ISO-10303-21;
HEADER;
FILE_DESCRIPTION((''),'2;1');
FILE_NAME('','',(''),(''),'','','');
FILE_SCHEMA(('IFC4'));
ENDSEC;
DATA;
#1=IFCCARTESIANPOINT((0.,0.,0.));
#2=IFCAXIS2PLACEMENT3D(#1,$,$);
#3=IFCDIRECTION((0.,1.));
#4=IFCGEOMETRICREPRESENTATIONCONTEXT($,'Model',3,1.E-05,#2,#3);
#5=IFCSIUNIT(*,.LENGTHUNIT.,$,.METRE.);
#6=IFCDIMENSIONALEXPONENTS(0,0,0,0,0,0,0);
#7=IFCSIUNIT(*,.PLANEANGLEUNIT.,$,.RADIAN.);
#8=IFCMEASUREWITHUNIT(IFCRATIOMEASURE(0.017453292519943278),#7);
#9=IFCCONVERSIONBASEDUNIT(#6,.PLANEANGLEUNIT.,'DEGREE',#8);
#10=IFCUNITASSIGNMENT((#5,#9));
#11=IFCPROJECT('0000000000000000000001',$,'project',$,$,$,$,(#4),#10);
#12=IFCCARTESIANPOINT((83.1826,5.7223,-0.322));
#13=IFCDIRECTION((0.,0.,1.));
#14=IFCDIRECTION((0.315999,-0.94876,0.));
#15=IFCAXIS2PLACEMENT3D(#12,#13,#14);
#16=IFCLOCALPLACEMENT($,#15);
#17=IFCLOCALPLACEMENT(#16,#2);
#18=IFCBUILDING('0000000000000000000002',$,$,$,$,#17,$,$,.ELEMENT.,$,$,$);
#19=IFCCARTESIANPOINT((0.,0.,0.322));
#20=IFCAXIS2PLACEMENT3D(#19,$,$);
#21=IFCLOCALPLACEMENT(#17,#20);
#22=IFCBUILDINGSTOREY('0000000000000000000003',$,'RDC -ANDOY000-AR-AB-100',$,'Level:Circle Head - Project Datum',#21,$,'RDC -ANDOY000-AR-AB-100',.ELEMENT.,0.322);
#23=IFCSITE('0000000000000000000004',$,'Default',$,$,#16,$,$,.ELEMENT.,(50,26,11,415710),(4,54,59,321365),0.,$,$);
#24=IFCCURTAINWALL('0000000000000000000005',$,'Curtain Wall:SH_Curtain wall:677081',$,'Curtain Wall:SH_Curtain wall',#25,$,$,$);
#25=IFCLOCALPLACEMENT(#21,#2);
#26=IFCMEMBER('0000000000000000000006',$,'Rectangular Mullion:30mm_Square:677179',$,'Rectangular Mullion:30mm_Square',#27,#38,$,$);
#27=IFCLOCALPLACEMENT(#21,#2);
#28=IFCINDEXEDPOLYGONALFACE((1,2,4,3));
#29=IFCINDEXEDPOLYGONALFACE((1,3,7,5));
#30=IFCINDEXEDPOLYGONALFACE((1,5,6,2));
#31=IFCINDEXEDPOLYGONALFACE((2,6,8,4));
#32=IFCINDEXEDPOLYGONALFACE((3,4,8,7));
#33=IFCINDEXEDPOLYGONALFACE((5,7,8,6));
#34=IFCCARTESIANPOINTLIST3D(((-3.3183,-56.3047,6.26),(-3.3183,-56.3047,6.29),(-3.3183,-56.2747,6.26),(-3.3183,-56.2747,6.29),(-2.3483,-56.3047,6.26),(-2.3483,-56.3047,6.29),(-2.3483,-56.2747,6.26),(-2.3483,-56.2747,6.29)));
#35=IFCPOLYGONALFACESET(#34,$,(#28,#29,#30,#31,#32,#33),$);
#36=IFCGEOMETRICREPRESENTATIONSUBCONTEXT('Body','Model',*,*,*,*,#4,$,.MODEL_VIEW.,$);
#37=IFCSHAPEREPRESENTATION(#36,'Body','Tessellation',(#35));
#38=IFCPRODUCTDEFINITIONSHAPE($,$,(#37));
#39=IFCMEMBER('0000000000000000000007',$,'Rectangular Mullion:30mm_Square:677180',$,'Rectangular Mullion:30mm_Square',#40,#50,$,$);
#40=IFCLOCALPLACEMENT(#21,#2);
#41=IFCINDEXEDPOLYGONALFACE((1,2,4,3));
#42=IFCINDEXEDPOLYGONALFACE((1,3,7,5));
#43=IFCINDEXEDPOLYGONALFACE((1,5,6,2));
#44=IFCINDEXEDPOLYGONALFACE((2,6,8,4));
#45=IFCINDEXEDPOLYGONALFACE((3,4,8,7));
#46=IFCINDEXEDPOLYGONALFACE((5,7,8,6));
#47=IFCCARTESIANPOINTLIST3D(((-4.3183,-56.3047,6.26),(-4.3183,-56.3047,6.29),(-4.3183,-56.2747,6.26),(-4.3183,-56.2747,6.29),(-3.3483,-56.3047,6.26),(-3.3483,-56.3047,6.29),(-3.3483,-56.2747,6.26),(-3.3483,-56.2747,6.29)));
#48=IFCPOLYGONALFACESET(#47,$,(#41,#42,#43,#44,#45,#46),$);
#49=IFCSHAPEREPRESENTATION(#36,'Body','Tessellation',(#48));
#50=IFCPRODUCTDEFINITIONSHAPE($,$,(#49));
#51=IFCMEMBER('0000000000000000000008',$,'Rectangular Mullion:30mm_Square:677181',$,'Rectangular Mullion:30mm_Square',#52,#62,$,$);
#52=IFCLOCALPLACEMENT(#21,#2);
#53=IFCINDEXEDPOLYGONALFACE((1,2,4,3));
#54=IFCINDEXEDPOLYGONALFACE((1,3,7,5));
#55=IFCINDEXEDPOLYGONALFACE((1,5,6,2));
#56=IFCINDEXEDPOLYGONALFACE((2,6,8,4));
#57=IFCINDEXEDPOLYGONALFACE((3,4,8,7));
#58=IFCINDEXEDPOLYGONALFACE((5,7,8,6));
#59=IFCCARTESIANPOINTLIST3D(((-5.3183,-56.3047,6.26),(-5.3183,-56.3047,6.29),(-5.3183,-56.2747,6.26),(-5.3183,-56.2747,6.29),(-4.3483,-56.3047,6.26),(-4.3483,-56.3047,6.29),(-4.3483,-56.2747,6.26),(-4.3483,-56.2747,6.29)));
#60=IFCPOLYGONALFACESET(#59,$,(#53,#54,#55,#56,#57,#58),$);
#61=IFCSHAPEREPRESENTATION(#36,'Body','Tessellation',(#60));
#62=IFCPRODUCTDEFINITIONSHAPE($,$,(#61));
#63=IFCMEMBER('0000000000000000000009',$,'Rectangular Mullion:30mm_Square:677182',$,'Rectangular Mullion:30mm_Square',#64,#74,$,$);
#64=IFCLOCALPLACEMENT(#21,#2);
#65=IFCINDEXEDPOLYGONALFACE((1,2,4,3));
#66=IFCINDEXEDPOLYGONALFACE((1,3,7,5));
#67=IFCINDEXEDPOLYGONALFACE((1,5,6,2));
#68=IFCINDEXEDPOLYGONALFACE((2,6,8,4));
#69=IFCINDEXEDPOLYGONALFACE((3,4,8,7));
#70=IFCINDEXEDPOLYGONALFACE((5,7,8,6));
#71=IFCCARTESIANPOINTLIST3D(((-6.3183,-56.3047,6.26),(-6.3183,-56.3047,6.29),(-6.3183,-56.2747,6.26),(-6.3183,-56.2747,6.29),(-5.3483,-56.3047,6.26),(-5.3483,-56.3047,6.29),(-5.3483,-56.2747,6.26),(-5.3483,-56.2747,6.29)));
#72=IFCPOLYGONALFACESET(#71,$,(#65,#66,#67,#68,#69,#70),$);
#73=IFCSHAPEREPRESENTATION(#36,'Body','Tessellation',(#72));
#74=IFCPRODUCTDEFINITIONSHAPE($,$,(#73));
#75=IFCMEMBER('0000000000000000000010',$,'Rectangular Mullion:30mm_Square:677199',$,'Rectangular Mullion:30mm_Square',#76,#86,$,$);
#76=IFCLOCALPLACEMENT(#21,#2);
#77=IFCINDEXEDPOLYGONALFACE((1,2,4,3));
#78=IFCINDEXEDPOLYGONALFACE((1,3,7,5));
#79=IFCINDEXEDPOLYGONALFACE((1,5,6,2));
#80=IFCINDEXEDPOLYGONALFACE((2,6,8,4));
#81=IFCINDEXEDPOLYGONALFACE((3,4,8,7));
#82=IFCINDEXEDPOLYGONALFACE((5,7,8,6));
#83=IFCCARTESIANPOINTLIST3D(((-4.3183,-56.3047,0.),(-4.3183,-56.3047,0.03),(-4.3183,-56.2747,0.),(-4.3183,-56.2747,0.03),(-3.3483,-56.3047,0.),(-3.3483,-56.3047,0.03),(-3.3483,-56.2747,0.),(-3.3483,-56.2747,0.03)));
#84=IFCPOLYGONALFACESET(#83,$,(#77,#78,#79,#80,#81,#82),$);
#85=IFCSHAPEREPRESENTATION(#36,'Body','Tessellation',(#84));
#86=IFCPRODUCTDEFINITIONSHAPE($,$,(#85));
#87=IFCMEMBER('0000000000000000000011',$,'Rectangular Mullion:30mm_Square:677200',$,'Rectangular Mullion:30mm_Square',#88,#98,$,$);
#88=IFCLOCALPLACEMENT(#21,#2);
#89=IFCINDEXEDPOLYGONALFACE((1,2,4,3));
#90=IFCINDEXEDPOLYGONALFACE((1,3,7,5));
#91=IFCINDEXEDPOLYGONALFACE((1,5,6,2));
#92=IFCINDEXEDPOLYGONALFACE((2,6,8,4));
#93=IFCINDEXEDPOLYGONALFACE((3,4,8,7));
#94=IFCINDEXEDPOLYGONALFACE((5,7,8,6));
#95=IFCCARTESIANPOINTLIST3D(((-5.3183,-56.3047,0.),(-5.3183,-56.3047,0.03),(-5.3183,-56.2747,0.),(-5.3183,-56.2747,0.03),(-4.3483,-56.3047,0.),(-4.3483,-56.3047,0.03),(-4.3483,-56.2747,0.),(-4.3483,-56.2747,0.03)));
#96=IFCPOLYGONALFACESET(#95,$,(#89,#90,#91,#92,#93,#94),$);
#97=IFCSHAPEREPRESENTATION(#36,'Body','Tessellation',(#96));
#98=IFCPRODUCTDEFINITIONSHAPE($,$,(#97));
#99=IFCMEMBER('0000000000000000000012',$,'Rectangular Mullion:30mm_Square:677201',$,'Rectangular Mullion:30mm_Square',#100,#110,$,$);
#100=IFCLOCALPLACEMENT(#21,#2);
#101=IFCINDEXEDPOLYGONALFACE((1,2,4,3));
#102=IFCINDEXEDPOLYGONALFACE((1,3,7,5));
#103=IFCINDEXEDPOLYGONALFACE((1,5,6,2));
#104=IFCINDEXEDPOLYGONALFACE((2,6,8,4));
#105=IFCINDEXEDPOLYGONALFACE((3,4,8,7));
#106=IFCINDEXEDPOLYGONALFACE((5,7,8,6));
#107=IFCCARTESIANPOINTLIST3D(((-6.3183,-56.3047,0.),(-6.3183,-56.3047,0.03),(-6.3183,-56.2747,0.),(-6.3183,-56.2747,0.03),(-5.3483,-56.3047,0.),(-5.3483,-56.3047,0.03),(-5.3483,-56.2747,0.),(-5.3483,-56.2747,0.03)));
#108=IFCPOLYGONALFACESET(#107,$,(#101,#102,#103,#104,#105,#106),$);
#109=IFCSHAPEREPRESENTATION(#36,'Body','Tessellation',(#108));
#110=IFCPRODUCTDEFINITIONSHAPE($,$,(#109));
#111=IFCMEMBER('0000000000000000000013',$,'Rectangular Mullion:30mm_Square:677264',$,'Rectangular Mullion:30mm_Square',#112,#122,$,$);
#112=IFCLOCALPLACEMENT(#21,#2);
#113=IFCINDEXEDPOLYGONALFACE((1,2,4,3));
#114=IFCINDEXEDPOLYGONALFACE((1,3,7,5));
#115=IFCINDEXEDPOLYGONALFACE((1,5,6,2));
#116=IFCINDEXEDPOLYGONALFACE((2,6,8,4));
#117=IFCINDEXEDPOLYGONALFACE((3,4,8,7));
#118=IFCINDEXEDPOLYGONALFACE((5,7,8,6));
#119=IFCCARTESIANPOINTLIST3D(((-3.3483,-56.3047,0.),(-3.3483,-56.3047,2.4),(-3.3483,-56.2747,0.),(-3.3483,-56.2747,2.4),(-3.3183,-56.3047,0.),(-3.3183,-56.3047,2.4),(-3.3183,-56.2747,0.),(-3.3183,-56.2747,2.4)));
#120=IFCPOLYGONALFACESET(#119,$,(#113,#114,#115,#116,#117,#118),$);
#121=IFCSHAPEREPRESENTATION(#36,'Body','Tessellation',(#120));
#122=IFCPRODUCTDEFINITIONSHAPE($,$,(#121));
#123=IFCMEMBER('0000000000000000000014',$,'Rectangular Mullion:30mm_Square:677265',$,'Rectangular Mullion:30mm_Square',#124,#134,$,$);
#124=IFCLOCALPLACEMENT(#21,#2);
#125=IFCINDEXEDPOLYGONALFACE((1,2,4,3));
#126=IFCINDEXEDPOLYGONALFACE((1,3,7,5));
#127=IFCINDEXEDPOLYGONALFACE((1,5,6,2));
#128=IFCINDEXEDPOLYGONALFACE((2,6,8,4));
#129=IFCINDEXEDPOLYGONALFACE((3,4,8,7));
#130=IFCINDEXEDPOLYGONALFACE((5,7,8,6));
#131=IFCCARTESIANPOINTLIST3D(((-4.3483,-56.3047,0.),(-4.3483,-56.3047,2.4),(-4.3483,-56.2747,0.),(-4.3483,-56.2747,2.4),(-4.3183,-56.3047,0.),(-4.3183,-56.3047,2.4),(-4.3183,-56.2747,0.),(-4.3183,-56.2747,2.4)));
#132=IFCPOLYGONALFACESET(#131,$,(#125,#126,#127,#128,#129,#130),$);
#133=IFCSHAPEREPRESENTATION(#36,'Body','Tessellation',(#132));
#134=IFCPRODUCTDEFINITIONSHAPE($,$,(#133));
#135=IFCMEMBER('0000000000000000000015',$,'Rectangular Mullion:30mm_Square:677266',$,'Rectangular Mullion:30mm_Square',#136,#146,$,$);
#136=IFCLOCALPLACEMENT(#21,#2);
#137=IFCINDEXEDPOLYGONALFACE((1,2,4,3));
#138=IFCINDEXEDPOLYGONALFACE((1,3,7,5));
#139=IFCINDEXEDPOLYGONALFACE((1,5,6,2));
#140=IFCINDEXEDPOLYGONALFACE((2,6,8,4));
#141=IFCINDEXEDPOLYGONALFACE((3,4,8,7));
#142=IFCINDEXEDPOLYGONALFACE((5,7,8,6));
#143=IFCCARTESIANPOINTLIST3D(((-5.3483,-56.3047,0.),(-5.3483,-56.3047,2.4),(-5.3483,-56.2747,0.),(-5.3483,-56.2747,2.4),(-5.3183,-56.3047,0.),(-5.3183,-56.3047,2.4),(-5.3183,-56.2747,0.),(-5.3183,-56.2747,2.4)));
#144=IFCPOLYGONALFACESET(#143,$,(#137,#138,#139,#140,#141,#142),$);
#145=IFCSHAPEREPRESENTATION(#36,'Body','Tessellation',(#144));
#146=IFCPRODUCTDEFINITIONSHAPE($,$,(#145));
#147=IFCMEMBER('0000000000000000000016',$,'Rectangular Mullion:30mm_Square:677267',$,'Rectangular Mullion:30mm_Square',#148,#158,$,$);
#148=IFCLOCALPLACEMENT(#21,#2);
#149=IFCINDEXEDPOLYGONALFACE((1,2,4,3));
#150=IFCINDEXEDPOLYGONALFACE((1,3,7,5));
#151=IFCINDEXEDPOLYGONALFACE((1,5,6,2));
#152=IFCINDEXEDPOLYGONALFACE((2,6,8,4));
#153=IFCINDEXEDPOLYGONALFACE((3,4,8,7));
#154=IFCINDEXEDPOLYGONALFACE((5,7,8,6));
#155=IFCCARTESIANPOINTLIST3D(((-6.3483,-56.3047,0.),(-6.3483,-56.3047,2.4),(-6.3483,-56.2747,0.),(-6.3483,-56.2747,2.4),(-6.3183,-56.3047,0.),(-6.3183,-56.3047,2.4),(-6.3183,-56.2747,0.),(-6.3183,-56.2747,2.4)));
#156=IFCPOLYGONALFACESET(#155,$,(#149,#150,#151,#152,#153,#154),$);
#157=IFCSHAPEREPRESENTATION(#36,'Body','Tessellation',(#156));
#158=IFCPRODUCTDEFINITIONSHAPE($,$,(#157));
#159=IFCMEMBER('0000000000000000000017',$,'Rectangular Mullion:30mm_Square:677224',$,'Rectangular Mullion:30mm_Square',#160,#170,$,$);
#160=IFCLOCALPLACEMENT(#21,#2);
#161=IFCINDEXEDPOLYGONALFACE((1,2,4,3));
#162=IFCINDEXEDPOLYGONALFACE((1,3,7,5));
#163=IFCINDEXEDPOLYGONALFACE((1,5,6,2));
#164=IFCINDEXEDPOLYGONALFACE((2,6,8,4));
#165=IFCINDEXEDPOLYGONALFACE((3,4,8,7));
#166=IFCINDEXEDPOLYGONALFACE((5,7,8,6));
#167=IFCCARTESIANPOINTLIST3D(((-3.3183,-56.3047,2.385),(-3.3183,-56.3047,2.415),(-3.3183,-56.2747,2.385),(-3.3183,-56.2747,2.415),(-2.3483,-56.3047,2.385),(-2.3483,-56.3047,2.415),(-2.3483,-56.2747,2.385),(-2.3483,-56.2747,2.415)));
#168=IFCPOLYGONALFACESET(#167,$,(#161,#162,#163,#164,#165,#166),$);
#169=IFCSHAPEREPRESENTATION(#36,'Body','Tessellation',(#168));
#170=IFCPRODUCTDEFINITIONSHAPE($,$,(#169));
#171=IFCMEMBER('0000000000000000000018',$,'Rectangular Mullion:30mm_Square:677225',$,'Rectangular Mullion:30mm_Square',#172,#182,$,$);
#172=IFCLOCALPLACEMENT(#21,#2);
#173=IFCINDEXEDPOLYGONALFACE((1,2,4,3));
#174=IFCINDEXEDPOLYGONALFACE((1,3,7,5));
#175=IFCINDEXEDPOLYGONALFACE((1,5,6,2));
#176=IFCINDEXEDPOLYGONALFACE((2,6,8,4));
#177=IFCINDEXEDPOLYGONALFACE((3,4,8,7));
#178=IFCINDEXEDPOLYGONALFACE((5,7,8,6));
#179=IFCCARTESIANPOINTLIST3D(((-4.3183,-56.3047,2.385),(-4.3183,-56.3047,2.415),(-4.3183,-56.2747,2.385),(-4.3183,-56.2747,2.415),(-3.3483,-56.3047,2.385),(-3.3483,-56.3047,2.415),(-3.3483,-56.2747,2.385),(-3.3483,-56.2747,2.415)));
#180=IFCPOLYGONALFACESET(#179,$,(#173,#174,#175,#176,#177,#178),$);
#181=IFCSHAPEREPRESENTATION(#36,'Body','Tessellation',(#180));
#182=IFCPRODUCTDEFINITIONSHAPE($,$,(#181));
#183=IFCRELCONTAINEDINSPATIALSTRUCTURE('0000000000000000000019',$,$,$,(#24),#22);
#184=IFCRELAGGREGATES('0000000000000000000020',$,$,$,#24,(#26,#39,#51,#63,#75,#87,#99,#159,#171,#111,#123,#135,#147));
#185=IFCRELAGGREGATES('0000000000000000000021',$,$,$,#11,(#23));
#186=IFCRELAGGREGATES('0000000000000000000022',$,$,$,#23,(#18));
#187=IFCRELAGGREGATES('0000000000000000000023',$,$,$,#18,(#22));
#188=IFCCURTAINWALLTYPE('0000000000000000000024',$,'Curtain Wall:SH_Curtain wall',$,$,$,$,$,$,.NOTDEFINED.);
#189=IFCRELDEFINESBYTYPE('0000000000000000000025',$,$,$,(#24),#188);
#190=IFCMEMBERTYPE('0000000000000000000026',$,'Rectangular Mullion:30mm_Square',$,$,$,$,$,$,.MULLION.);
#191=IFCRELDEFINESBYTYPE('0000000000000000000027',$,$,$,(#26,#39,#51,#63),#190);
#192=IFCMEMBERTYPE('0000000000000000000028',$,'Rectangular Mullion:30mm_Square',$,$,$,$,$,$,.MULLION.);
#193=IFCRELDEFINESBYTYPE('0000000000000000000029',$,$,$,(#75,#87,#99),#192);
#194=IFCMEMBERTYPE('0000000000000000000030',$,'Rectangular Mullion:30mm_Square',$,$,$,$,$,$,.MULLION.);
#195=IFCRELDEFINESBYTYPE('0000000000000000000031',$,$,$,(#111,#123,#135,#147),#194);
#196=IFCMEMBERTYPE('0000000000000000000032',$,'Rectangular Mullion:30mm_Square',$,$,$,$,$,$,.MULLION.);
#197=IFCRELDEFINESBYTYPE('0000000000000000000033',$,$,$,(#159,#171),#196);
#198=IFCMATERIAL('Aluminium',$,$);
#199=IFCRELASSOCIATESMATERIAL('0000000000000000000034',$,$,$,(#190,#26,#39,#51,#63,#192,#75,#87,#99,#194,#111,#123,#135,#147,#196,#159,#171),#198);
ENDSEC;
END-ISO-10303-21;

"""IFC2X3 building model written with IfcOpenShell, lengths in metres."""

from ifc_helpers import new_model, entity, si_unit, converted_unit, direction, frame, origin, origin_2d_with_axis, place, context, subcontext, project, spatial, rectangle, extrude, source, transform, mapped, material, type_object, type_shapes, element, aggregate, save


model = new_model("IFC2X3")

# Units and contexts
model_context = context("Model", 3, precision=1e-05, world=origin(), true_north=direction((0.0, 1.0)))
body_context = subcontext(model_context, "Body", "Model", "MODEL_VIEW")
ifc_project = project(units=[si_unit("LENGTHUNIT", "METRE"), converted_unit("PLANEANGLEUNIT", "DEGREE", entity("IfcRatioMeasure", 0.017453292519943278), si_unit("PLANEANGLEUNIT", "RADIAN"), dimensions=[0, 0, 0, 0, 0, 0, 0])], contexts=[model_context])

# Site, building, storey
site_placement = place(None, frame((83.1826, 5.7223, -0.322), z_axis=(0.0, 0.0, 1.0), x_axis=(0.315999, -0.94876, 0.0)))
site = spatial("IfcSite", under=ifc_project, at=site_placement, Name="Default", CompositionType="ELEMENT", RefLatitude=(50, 26, 11, 415710), RefLongitude=(4, 54, 59, 321365), RefElevation=0.0)
building_placement = place(site_placement, origin())
building = spatial("IfcBuilding", under=site, at=building_placement, CompositionType="ELEMENT")
storey_placement = place(building_placement, frame((0.0, 0.0, 0.322)))
storey = spatial("IfcBuildingStorey", under=building, at=storey_placement, Name="RDC -ANDOY000-AR-AB-100", ObjectType="Level:Circle Head - Project Datum", LongName="RDC -ANDOY000-AR-AB-100", CompositionType="ELEMENT", Elevation=0.322)

# Curtain wall, members
curtain_wall_type = type_object("IfcCurtainWallType", Name="Curtain Wall:SH_Curtain wall", PredefinedType="NOTDEFINED")
curtain_wall_placement = place(storey_placement, frame((0.0, 0.0, -0.322)))
curtain_wall = element("IfcCurtainWall", 1, at=curtain_wall_placement, inside=storey, type_object=curtain_wall_type, Name="Curtain Wall:SH_Curtain wall:677081", ObjectType="Curtain Wall:SH_Curtain wall")
ifc_material_1 = material(Name="Aluminium")
member_type_1 = type_object("IfcMemberType", Name="Rectangular Mullion:30mm_Square", PredefinedType="MULLION", material=ifc_material_1)
shared_shape_1 = source(origin(), body_context, "Body", "SweptSolid", [
    extrude(rectangle(XDim=0.03, YDim=0.03, at=origin_2d_with_axis()), frame((-0.015, 0.0, -0.97), z_axis=(0.0, 0.0, 1.0), x_axis=(0.0, -1.0, 0.0)), (0.0, 0.0, 1.0), 0.97),
])
type_shapes(member_type_1, [shared_shape_1])
member_1_placement = place(curtain_wall_placement, frame((-3.3183, -56.2897, 6.612), z_axis=(-1.0, 0.0, 0.0), x_axis=(0.0, 0.0, 1.0)))
member_1 = element("IfcMember", 2, at=member_1_placement, type_object=member_type_1, material=ifc_material_1, Name="Rectangular Mullion:30mm_Square:677179", ObjectType="Rectangular Mullion:30mm_Square", context=body_context, shape_type="MappedRepresentation", body=[
    mapped(shared_shape_1, transform((0.0, 0.0, 0.0), scale=1.0)),
])
member_2_placement = place(curtain_wall_placement, frame((-4.3183, -56.2897, 6.612), z_axis=(-1.0, 0.0, 0.0), x_axis=(0.0, 0.0, 1.0)))
member_2 = element("IfcMember", 3, at=member_2_placement, type_object=member_type_1, material=ifc_material_1, Name="Rectangular Mullion:30mm_Square:677180", ObjectType="Rectangular Mullion:30mm_Square", context=body_context, shape_type="MappedRepresentation", body=[
    mapped(shared_shape_1, transform((0.0, 0.0, 0.0), scale=1.0)),
])
member_3_placement = place(curtain_wall_placement, frame((-5.3183, -56.2897, 6.612), z_axis=(-1.0, 0.0, 0.0), x_axis=(0.0, 0.0, 1.0)))
member_3 = element("IfcMember", 4, at=member_3_placement, type_object=member_type_1, material=ifc_material_1, Name="Rectangular Mullion:30mm_Square:677181", ObjectType="Rectangular Mullion:30mm_Square", context=body_context, shape_type="MappedRepresentation", body=[
    mapped(shared_shape_1, transform((0.0, 0.0, 0.0), scale=1.0)),
])
member_4_placement = place(curtain_wall_placement, frame((-6.3183, -56.2897, 6.612), z_axis=(-1.0, 0.0, 0.0), x_axis=(0.0, 0.0, 1.0)))
member_4 = element("IfcMember", 5, at=member_4_placement, type_object=member_type_1, material=ifc_material_1, Name="Rectangular Mullion:30mm_Square:677182", ObjectType="Rectangular Mullion:30mm_Square", context=body_context, shape_type="MappedRepresentation", body=[
    mapped(shared_shape_1, transform((0.0, 0.0, 0.0), scale=1.0)),
])
member_type_2 = type_object("IfcMemberType", Name="Rectangular Mullion:30mm_Square", PredefinedType="MULLION", material=ifc_material_1)
shared_shape_2 = source(origin(), body_context, "Body", "SweptSolid", [
    extrude(rectangle(XDim=0.03, YDim=0.03, at=origin_2d_with_axis()), frame((-0.015, 0.0, -0.97), z_axis=(0.0, 0.0, 1.0), x_axis=(0.0, -1.0, 0.0)), (0.0, 0.0, 1.0), 0.97),
])
type_shapes(member_type_2, [shared_shape_2])
member_5_placement = place(curtain_wall_placement, frame((-3.3483, -56.2897, 0.322), z_axis=(1.0, 0.0, 0.0), x_axis=(0.0, 0.0, -1.0)))
member_5 = element("IfcMember", 6, at=member_5_placement, type_object=member_type_2, material=ifc_material_1, Name="Rectangular Mullion:30mm_Square:677199", ObjectType="Rectangular Mullion:30mm_Square", context=body_context, shape_type="MappedRepresentation", body=[
    mapped(shared_shape_2, transform((0.0, 0.0, 0.0), scale=1.0)),
])
member_6_placement = place(curtain_wall_placement, frame((-4.3483, -56.2897, 0.322), z_axis=(1.0, 0.0, 0.0), x_axis=(0.0, 0.0, -1.0)))
member_6 = element("IfcMember", 7, at=member_6_placement, type_object=member_type_2, material=ifc_material_1, Name="Rectangular Mullion:30mm_Square:677200", ObjectType="Rectangular Mullion:30mm_Square", context=body_context, shape_type="MappedRepresentation", body=[
    mapped(shared_shape_2, transform((0.0, 0.0, 0.0), scale=1.0)),
])
member_7_placement = place(curtain_wall_placement, frame((-5.3483, -56.2897, 0.322), z_axis=(1.0, 0.0, 0.0), x_axis=(0.0, 0.0, -1.0)))
member_7 = element("IfcMember", 8, at=member_7_placement, type_object=member_type_2, material=ifc_material_1, Name="Rectangular Mullion:30mm_Square:677201", ObjectType="Rectangular Mullion:30mm_Square", context=body_context, shape_type="MappedRepresentation", body=[
    mapped(shared_shape_2, transform((0.0, 0.0, 0.0), scale=1.0)),
])
member_type_3 = type_object("IfcMemberType", Name="Rectangular Mullion:30mm_Square", PredefinedType="MULLION", material=ifc_material_1)
shared_shape_3 = source(origin(), body_context, "Body", "SweptSolid", [
    extrude(rectangle(XDim=0.03, YDim=0.03, at=origin_2d_with_axis()), frame((0.0, 0.0, -2.4), z_axis=(0.0, 0.0, 1.0), x_axis=(0.0, -1.0, 0.0)), (0.0, 0.0, 1.0), 2.4),
])
type_shapes(member_type_3, [shared_shape_3])
member_8_placement = place(curtain_wall_placement, frame((-3.3333, -56.2897, 0.322), z_axis=(0.0, 0.0, -1.0), x_axis=(-1.0, 0.0, 0.0)))
member_8 = element("IfcMember", 9, at=member_8_placement, type_object=member_type_3, material=ifc_material_1, Name="Rectangular Mullion:30mm_Square:677264", ObjectType="Rectangular Mullion:30mm_Square", context=body_context, shape_type="MappedRepresentation", body=[
    mapped(shared_shape_3, transform((0.0, 0.0, 0.0), scale=1.0)),
])
member_9_placement = place(curtain_wall_placement, frame((-4.3333, -56.2897, 0.322), z_axis=(0.0, 0.0, -1.0), x_axis=(-1.0, 0.0, 0.0)))
member_9 = element("IfcMember", 10, at=member_9_placement, type_object=member_type_3, material=ifc_material_1, Name="Rectangular Mullion:30mm_Square:677265", ObjectType="Rectangular Mullion:30mm_Square", context=body_context, shape_type="MappedRepresentation", body=[
    mapped(shared_shape_3, transform((0.0, 0.0, 0.0), scale=1.0)),
])
member_10_placement = place(curtain_wall_placement, frame((-5.3333, -56.2897, 0.322), z_axis=(0.0, 0.0, -1.0), x_axis=(-1.0, 0.0, 0.0)))
member_10 = element("IfcMember", 11, at=member_10_placement, type_object=member_type_3, material=ifc_material_1, Name="Rectangular Mullion:30mm_Square:677266", ObjectType="Rectangular Mullion:30mm_Square", context=body_context, shape_type="MappedRepresentation", body=[
    mapped(shared_shape_3, transform((0.0, 0.0, 0.0), scale=1.0)),
])
member_11_placement = place(curtain_wall_placement, frame((-6.3333, -56.2897, 0.322), z_axis=(0.0, 0.0, -1.0), x_axis=(-1.0, 0.0, 0.0)))
member_11 = element("IfcMember", 12, at=member_11_placement, type_object=member_type_3, material=ifc_material_1, Name="Rectangular Mullion:30mm_Square:677267", ObjectType="Rectangular Mullion:30mm_Square", context=body_context, shape_type="MappedRepresentation", body=[
    mapped(shared_shape_3, transform((0.0, 0.0, 0.0), scale=1.0)),
])
member_type_4 = type_object("IfcMemberType", Name="Rectangular Mullion:30mm_Square", PredefinedType="MULLION", material=ifc_material_1)
shared_shape_4 = source(origin(), body_context, "Body", "SweptSolid", [
    extrude(rectangle(XDim=0.03, YDim=0.03, at=origin_2d_with_axis()), frame((0.0, 0.0, -0.97), z_axis=(0.0, 0.0, 1.0), x_axis=(0.0, -1.0, 0.0)), (0.0, 0.0, 1.0), 0.97),
])
type_shapes(member_type_4, [shared_shape_4])
member_12_placement = place(curtain_wall_placement, frame((-3.3183, -56.2897, 2.722), z_axis=(-1.0, 0.0, 0.0), x_axis=(0.0, 0.0, 1.0)))
member_12 = element("IfcMember", 13, at=member_12_placement, type_object=member_type_4, material=ifc_material_1, Name="Rectangular Mullion:30mm_Square:677224", ObjectType="Rectangular Mullion:30mm_Square", context=body_context, shape_type="MappedRepresentation", body=[
    mapped(shared_shape_4, transform((0.0, 0.0, 0.0), scale=1.0)),
])
member_13_placement = place(curtain_wall_placement, frame((-4.3183, -56.2897, 2.722), z_axis=(-1.0, 0.0, 0.0), x_axis=(0.0, 0.0, 1.0)))
member_13 = element("IfcMember", 14, at=member_13_placement, type_object=member_type_4, material=ifc_material_1, Name="Rectangular Mullion:30mm_Square:677225", ObjectType="Rectangular Mullion:30mm_Square", context=body_context, shape_type="MappedRepresentation", body=[
    mapped(shared_shape_4, transform((0.0, 0.0, 0.0), scale=1.0)),
])
aggregate(curtain_wall, [member_1, member_2, member_3, member_4, member_5, member_6, member_7, member_12, member_13, member_8, member_9, member_10, member_11])

save(model, "model.ifc")
